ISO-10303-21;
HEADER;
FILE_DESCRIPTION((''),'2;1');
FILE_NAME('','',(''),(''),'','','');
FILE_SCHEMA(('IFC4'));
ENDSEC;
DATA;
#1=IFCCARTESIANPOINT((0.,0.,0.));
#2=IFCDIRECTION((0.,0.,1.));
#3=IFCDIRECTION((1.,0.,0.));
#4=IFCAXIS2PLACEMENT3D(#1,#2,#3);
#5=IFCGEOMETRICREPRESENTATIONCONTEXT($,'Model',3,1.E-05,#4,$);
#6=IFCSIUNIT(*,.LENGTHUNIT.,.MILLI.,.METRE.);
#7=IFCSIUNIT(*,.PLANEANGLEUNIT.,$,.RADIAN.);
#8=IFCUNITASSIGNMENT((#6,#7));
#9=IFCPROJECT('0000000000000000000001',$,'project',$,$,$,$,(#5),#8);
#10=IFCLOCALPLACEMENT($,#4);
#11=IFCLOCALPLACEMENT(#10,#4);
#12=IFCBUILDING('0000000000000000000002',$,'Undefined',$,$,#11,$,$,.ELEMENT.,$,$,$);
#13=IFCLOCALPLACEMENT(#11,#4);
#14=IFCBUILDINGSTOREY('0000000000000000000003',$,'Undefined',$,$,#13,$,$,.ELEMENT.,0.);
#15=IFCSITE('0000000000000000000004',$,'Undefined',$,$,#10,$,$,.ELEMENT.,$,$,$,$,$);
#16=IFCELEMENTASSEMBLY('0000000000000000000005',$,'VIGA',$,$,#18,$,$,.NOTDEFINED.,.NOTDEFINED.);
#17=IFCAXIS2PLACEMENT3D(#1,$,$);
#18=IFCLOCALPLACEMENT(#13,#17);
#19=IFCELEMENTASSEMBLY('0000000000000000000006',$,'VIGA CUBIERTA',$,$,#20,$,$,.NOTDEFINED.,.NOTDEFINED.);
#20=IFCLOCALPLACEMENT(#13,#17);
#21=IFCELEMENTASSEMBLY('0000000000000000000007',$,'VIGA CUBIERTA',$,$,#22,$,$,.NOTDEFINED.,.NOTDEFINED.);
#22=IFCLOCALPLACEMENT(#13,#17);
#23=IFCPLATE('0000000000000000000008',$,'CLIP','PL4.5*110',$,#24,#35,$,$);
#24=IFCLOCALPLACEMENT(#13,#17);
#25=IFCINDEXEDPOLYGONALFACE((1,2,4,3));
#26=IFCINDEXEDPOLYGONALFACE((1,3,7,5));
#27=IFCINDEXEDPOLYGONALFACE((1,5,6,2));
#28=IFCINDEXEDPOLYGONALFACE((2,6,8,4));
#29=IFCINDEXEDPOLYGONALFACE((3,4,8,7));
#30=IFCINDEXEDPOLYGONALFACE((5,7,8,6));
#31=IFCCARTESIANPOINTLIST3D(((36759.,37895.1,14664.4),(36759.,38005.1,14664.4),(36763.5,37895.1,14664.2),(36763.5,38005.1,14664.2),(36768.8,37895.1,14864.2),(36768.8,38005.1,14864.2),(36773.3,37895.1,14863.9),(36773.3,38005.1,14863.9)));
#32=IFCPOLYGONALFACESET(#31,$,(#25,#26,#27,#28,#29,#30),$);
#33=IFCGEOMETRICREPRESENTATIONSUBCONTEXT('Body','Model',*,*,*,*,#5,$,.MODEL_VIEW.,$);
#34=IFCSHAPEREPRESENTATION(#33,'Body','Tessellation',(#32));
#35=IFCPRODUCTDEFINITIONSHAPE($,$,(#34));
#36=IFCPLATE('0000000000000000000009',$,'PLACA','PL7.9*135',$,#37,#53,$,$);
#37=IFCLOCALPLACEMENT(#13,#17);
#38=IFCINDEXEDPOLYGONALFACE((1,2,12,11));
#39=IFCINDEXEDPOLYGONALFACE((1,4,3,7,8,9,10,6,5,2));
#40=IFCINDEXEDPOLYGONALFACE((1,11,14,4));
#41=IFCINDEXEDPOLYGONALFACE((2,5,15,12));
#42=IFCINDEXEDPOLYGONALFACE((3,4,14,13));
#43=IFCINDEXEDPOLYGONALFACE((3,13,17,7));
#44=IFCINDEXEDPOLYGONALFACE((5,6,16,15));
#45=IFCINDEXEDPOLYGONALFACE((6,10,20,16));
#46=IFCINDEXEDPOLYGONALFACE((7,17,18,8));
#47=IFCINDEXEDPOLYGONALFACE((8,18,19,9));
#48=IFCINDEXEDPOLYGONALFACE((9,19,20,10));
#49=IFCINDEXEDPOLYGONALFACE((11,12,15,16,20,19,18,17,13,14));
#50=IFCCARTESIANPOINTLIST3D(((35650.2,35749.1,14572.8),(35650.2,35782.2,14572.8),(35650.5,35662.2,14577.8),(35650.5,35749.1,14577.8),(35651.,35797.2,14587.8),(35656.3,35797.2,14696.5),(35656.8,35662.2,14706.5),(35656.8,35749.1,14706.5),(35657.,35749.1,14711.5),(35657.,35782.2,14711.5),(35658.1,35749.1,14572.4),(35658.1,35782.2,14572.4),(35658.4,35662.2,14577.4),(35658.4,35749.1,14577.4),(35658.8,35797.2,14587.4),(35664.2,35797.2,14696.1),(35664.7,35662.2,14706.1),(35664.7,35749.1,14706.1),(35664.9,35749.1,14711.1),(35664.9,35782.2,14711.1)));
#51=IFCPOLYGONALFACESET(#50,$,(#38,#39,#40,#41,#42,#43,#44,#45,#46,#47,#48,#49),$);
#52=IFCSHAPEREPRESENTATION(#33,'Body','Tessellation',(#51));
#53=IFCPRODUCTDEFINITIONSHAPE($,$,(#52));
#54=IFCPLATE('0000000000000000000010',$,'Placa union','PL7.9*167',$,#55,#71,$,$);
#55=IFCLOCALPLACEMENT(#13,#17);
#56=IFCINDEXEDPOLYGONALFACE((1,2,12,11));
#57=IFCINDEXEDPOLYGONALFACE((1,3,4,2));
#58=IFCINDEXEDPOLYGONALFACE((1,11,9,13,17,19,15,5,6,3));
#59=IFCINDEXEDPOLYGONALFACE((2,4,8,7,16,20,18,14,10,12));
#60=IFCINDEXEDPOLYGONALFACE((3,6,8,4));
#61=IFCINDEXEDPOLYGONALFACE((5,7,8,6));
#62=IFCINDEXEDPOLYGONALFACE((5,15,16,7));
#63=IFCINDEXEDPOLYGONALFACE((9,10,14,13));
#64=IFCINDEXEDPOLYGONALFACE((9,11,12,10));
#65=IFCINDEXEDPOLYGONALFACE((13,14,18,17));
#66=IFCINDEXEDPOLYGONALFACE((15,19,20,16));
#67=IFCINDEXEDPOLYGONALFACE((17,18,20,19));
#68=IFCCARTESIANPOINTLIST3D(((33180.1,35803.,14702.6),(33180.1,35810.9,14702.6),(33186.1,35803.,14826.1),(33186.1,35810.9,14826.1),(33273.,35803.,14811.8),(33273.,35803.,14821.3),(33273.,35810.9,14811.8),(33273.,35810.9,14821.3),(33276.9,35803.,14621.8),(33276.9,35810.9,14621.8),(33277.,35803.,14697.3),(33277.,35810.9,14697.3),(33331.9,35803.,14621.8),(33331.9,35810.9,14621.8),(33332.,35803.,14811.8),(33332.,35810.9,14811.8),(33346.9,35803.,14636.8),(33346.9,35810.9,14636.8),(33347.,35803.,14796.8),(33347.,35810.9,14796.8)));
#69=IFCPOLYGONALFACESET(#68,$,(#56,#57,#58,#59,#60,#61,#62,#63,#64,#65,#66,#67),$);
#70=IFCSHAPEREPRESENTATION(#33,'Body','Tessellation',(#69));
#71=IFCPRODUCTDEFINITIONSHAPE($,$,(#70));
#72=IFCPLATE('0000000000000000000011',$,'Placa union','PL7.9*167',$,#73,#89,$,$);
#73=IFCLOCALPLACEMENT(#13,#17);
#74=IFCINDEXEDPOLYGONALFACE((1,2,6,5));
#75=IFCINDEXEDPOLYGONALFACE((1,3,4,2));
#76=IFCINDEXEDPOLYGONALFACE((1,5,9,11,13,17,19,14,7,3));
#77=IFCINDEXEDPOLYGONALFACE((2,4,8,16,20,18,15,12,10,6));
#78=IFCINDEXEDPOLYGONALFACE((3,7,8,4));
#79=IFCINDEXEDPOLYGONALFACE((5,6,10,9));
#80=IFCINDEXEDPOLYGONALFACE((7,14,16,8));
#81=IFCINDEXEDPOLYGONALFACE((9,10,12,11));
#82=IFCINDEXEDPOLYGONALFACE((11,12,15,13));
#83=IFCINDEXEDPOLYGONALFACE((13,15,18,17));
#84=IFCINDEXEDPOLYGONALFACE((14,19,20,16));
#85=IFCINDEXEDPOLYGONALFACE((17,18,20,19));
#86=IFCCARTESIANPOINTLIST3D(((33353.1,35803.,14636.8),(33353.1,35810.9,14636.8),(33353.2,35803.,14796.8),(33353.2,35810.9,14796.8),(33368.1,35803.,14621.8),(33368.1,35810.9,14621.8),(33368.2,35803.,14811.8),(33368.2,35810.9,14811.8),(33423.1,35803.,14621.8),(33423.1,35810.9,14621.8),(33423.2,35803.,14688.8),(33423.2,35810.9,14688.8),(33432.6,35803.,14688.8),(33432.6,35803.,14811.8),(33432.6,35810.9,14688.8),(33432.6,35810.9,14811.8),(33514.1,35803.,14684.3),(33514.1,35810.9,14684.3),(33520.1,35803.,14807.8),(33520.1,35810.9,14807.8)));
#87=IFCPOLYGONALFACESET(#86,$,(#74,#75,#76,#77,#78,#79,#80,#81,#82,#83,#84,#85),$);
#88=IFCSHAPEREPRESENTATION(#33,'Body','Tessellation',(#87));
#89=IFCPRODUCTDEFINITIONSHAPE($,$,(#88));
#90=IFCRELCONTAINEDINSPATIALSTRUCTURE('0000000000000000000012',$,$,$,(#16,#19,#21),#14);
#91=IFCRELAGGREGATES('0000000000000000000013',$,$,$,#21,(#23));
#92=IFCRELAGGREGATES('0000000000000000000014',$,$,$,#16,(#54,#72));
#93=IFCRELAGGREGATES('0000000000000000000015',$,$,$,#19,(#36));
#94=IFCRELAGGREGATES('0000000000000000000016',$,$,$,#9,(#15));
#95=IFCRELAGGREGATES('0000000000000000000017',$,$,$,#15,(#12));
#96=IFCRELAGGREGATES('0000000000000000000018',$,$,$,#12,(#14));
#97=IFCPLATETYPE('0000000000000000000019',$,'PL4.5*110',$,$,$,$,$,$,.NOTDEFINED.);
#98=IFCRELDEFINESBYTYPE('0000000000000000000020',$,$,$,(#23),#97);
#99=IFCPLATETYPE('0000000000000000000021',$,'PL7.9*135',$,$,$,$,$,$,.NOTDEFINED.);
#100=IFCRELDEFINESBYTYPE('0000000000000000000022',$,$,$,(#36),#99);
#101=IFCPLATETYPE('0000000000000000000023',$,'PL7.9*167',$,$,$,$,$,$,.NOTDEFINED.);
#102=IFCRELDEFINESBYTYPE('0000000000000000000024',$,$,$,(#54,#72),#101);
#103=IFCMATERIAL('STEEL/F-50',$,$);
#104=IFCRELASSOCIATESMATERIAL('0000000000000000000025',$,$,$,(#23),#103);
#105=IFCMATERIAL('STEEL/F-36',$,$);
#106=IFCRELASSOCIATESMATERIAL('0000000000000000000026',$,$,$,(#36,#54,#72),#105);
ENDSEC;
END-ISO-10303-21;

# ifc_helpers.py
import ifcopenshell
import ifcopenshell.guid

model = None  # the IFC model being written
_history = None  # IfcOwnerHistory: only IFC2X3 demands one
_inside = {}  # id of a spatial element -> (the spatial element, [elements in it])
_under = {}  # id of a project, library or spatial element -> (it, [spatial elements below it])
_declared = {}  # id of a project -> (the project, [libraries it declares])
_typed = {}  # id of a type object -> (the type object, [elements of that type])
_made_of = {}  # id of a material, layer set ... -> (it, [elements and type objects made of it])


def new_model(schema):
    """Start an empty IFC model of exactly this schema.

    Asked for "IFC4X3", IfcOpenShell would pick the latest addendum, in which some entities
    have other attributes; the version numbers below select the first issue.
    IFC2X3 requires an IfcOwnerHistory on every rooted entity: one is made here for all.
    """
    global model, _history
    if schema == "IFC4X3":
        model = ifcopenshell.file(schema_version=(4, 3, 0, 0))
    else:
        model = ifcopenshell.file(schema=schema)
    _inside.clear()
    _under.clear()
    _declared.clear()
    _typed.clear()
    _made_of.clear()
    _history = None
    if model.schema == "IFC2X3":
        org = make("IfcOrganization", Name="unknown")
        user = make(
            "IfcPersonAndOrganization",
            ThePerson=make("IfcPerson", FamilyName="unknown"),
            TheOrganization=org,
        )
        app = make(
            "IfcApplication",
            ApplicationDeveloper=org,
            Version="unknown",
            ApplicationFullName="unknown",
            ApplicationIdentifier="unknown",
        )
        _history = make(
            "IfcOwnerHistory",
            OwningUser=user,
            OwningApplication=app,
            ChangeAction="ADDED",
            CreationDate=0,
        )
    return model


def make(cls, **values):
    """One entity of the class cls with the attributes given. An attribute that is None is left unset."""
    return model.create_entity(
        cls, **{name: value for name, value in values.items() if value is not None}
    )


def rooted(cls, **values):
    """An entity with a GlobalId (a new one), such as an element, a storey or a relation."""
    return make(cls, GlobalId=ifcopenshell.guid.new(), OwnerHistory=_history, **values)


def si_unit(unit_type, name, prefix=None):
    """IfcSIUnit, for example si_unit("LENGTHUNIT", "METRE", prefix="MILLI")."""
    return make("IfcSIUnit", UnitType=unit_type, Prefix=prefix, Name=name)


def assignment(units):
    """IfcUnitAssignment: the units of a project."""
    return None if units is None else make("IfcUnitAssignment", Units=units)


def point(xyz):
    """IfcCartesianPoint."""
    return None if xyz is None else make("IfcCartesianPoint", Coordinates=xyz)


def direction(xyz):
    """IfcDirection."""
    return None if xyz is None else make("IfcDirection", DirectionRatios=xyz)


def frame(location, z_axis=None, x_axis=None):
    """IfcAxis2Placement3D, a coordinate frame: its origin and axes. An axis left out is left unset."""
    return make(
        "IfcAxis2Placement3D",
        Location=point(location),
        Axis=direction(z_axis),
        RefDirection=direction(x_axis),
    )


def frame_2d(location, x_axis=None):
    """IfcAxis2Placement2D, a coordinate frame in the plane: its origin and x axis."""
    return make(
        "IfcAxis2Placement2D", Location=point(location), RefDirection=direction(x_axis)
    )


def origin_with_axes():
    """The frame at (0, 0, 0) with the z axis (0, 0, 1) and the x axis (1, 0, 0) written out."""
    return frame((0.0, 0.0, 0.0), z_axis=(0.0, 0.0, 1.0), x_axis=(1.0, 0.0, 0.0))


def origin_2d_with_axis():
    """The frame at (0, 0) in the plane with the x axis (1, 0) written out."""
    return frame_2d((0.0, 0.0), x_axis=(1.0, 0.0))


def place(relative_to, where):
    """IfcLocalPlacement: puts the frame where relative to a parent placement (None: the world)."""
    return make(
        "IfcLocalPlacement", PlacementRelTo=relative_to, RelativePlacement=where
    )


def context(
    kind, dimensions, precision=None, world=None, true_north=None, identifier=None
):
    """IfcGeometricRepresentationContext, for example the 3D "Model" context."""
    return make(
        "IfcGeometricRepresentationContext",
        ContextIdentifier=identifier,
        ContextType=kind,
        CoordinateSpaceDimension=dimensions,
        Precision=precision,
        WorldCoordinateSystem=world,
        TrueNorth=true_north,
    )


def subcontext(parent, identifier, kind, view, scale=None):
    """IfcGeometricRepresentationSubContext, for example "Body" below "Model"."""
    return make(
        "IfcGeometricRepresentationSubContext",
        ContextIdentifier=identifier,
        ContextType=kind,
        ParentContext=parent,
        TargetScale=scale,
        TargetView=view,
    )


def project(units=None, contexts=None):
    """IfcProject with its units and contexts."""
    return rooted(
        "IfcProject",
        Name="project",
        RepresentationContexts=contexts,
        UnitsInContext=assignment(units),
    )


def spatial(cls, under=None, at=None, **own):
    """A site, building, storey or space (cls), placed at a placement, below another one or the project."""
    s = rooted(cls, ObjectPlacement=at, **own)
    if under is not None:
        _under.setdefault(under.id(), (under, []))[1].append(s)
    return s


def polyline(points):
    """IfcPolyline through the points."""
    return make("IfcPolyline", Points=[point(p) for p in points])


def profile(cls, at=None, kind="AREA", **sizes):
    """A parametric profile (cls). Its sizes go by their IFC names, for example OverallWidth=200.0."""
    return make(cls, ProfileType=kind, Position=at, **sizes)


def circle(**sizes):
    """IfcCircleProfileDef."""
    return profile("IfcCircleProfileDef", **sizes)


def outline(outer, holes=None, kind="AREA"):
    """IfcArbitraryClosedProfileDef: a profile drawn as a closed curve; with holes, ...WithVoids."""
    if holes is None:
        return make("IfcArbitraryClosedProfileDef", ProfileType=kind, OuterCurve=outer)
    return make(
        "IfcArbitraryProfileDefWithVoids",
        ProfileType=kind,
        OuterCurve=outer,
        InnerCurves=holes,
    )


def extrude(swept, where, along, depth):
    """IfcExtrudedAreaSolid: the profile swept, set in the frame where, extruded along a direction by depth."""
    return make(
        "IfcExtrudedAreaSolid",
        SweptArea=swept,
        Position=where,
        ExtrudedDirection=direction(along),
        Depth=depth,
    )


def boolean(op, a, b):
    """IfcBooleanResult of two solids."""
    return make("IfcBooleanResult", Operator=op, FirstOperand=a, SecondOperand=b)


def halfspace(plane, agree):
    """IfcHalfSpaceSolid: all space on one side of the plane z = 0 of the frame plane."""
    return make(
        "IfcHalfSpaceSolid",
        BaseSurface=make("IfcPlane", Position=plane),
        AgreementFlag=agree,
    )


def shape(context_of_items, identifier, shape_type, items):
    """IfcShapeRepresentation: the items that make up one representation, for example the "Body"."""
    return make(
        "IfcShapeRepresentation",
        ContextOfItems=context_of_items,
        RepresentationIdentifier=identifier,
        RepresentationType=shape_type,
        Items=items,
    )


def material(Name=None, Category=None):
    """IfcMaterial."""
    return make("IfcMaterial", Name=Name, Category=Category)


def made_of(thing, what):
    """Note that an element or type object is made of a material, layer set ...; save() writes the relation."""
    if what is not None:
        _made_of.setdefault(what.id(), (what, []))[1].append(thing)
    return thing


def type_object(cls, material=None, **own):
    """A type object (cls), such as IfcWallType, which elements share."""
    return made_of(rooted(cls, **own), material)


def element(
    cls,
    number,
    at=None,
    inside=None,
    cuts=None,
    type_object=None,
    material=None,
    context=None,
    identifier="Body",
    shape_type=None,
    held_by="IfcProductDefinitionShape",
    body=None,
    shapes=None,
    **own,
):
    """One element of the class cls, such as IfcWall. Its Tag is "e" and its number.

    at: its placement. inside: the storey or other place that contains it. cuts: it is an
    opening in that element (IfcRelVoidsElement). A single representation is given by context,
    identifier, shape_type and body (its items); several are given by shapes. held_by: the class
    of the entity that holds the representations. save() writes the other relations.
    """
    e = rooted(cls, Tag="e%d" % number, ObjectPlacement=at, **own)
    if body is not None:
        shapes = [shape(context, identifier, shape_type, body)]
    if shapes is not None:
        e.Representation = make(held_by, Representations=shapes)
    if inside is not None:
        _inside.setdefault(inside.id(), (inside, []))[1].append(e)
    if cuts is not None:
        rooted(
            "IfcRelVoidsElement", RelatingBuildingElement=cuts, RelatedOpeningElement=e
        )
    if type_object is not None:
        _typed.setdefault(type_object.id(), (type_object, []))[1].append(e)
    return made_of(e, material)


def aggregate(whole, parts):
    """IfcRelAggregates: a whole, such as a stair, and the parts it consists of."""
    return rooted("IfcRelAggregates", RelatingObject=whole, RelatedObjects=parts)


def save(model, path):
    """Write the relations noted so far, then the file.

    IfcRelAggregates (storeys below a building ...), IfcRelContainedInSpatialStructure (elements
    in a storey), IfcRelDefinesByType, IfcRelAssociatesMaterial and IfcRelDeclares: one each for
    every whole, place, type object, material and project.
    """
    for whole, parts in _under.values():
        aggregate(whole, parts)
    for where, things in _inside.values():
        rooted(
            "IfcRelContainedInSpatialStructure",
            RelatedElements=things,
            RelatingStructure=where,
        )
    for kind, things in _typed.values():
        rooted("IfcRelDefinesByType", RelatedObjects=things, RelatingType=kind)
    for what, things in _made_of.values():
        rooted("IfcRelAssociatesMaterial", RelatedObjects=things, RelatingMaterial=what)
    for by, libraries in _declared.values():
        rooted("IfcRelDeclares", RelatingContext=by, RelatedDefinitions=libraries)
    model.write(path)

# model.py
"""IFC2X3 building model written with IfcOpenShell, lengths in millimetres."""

from ifc_helpers import new_model, si_unit, frame, origin_with_axes, origin_2d_with_axis, place, context, subcontext, project, spatial, polyline, circle, outline, extrude, boolean, halfspace, material, type_object, element, aggregate, save


model = new_model("IFC2X3")

# Units and contexts
model_context = context("Model", 3, precision=1e-05, world=origin_with_axes())
body_context = subcontext(model_context, "Body", "Model", "MODEL_VIEW")
ifc_project = project(units=[si_unit("LENGTHUNIT", "METRE", prefix="MILLI"), si_unit("PLANEANGLEUNIT", "RADIAN")], contexts=[model_context])

# Site, building, storey
site_placement = place(None, origin_with_axes())
site = spatial("IfcSite", under=ifc_project, at=site_placement, Name="Undefined", CompositionType="ELEMENT")
building_placement = place(site_placement, origin_with_axes())
building = spatial("IfcBuilding", under=site, at=building_placement, Name="Undefined", CompositionType="ELEMENT")
storey_placement = place(building_placement, origin_with_axes())
storey = spatial("IfcBuildingStorey", under=building, at=storey_placement, Name="Undefined", CompositionType="ELEMENT", Elevation=0.0)

# Shared definitions
ifc_material_1 = material(Name="STEEL/F-36")

# Element assembly
assembly_1_placement = place(storey_placement, origin_with_axes())
assembly_1 = element("IfcElementAssembly", 1, at=assembly_1_placement, inside=storey, Name="VIGA", AssemblyPlace="NOTDEFINED", PredefinedType="NOTDEFINED")
ifc_material_2 = material(Name="STEEL/F-50")
plate_type_1 = type_object("IfcPlateType", Name="PL4.5*110", PredefinedType="NOTDEFINED")

# Element assemblies, plate
assembly_2_placement = place(storey_placement, origin_with_axes())
assembly_2 = element("IfcElementAssembly", 2, at=assembly_2_placement, inside=storey, Name="VIGA CUBIERTA", AssemblyPlace="NOTDEFINED", PredefinedType="NOTDEFINED")
assembly_3_placement = place(storey_placement, origin_with_axes())
assembly_3 = element("IfcElementAssembly", 3, at=assembly_3_placement, inside=storey, Name="VIGA CUBIERTA", AssemblyPlace="NOTDEFINED", PredefinedType="NOTDEFINED")
plate_1_placement = place(assembly_3_placement, frame((36761.2, 37895.1, 14664.3), z_axis=(0.998794, 0.0, -0.049091), x_axis=(0.0, 1.0, 0.0)))
plate_1 = element("IfcPlate", 4, at=plate_1_placement, type_object=plate_type_1, material=ifc_material_2, Name="CLIP", Description="PL4.5*110", context=body_context, shape_type="SweptSolid", body=[
    extrude(outline(polyline([(0.0, 0.0), (110.0, 0.0), (110.0, 200.0), (0.0, 200.0), (0.0, 0.0)])), frame((0.0, 0.0, -2.2), z_axis=(0.0, 0.0, 1.0), x_axis=(1.0, 0.0, 0.0)), (0.0, 0.0, 1.0), 4.5),
])
aggregate(assembly_3, [plate_1])

# Plates
plate_type_2 = type_object("IfcPlateType", Name="PL7.9*135", PredefinedType="NOTDEFINED")
plate_2_placement = place(assembly_2_placement, frame((35660.7, 35662.2, 14706.3), z_axis=(-0.998794, 0.0, 0.049092), x_axis=(-0.000001, 1.0, -0.000031)))
solid_1 = boolean("DIFFERENCE", extrude(circle(Radius=161.9, at=origin_2d_with_axis()), frame((-264.2, 57.9, 3451.0), z_axis=(0.0, 0.0, -1.0), x_axis=(1.0, -0.000031, 0.0)), (0.0, 0.0, 1.0), 20715.6), halfspace(frame((-264.2, 57.9, 3428.8), z_axis=(0.0, 0.0, -1.0), x_axis=(-1.0, 0.000031, 0.0)), True))
plate_2 = element("IfcPlate", 5, at=plate_2_placement, type_object=plate_type_2, material=ifc_material_1, Name="PLACA", Description="PL7.9*135", context=body_context, shape_type="CSG", body=[
    boolean("DIFFERENCE", extrude(outline(polyline([(0.0, 0.0), (86.9, 0.0), (86.9, -5.0), (120.0, -5.0), (135.0, 10.0), (135.0, 118.8), (120.0, 133.8), (86.9, 133.8), (86.9, 128.8), (0.0, 128.8), (0.0, 0.0)])), frame((0.0, 0.0, -4.0), z_axis=(0.0, 0.0, 1.0), x_axis=(1.0, 0.0, 0.0)), (0.0, 0.0, 1.0), 7.9), solid_1),
])
plate_type_3 = type_object("IfcPlateType", Name="PL7.9*167", PredefinedType="NOTDEFINED")
plate_3_placement = place(assembly_1_placement, frame((33347.0, 35806.9, 14811.8), z_axis=(0.0, -1.0, 0.0), x_axis=(-1.0, 0.0, 0.0)))
plate_3 = element("IfcPlate", 6, at=plate_3_placement, type_object=plate_type_3, material=ifc_material_1, Name="Placa union", Description="PL7.9*167", context=body_context, shape_type="SweptSolid", body=[
    extrude(outline(polyline([(0.0, 15.0), (15.0, 0.0), (74.0, 0.0), (74.0, -9.6), (160.9, -14.3), (166.9, 109.1), (70.0, 114.5), (70.1, 189.9), (15.1, 189.9), (0.1, 174.9), (0.0, 15.0)])), frame((0.0, 0.0, -4.0), z_axis=(0.0, 0.0, 1.0), x_axis=(1.0, 0.0, 0.0)), (0.0, 0.0, 1.0), 7.9),
])
plate_4_placement = place(assembly_1_placement, frame((33353.2, 35806.9, 14811.8), z_axis=(0.0, 1.0, 0.0), x_axis=(1.0, 0.0, 0.0)))
plate_4 = element("IfcPlate", 7, at=plate_4_placement, type_object=plate_type_3, material=ifc_material_1, Name="Placa union", Description="PL7.9*167", context=body_context, shape_type="SweptSolid", body=[
    extrude(outline(polyline([(0.0, 15.0), (15.0, 0.0), (79.4, 0.0), (166.9, 4.0), (160.9, 127.5), (79.4, 123.0), (70.0, 123.0), (69.9, 189.9), (14.9, 189.9), (-0.1, 174.9), (0.0, 15.0)])), frame((0.0, 0.0, -4.0), z_axis=(0.0, 0.0, 1.0), x_axis=(1.0, 0.0, 0.0)), (0.0, 0.0, 1.0), 7.9),
])
aggregate(assembly_1, [plate_3, plate_4])

aggregate(assembly_2, [plate_2])

save(model, "model.ifc")
